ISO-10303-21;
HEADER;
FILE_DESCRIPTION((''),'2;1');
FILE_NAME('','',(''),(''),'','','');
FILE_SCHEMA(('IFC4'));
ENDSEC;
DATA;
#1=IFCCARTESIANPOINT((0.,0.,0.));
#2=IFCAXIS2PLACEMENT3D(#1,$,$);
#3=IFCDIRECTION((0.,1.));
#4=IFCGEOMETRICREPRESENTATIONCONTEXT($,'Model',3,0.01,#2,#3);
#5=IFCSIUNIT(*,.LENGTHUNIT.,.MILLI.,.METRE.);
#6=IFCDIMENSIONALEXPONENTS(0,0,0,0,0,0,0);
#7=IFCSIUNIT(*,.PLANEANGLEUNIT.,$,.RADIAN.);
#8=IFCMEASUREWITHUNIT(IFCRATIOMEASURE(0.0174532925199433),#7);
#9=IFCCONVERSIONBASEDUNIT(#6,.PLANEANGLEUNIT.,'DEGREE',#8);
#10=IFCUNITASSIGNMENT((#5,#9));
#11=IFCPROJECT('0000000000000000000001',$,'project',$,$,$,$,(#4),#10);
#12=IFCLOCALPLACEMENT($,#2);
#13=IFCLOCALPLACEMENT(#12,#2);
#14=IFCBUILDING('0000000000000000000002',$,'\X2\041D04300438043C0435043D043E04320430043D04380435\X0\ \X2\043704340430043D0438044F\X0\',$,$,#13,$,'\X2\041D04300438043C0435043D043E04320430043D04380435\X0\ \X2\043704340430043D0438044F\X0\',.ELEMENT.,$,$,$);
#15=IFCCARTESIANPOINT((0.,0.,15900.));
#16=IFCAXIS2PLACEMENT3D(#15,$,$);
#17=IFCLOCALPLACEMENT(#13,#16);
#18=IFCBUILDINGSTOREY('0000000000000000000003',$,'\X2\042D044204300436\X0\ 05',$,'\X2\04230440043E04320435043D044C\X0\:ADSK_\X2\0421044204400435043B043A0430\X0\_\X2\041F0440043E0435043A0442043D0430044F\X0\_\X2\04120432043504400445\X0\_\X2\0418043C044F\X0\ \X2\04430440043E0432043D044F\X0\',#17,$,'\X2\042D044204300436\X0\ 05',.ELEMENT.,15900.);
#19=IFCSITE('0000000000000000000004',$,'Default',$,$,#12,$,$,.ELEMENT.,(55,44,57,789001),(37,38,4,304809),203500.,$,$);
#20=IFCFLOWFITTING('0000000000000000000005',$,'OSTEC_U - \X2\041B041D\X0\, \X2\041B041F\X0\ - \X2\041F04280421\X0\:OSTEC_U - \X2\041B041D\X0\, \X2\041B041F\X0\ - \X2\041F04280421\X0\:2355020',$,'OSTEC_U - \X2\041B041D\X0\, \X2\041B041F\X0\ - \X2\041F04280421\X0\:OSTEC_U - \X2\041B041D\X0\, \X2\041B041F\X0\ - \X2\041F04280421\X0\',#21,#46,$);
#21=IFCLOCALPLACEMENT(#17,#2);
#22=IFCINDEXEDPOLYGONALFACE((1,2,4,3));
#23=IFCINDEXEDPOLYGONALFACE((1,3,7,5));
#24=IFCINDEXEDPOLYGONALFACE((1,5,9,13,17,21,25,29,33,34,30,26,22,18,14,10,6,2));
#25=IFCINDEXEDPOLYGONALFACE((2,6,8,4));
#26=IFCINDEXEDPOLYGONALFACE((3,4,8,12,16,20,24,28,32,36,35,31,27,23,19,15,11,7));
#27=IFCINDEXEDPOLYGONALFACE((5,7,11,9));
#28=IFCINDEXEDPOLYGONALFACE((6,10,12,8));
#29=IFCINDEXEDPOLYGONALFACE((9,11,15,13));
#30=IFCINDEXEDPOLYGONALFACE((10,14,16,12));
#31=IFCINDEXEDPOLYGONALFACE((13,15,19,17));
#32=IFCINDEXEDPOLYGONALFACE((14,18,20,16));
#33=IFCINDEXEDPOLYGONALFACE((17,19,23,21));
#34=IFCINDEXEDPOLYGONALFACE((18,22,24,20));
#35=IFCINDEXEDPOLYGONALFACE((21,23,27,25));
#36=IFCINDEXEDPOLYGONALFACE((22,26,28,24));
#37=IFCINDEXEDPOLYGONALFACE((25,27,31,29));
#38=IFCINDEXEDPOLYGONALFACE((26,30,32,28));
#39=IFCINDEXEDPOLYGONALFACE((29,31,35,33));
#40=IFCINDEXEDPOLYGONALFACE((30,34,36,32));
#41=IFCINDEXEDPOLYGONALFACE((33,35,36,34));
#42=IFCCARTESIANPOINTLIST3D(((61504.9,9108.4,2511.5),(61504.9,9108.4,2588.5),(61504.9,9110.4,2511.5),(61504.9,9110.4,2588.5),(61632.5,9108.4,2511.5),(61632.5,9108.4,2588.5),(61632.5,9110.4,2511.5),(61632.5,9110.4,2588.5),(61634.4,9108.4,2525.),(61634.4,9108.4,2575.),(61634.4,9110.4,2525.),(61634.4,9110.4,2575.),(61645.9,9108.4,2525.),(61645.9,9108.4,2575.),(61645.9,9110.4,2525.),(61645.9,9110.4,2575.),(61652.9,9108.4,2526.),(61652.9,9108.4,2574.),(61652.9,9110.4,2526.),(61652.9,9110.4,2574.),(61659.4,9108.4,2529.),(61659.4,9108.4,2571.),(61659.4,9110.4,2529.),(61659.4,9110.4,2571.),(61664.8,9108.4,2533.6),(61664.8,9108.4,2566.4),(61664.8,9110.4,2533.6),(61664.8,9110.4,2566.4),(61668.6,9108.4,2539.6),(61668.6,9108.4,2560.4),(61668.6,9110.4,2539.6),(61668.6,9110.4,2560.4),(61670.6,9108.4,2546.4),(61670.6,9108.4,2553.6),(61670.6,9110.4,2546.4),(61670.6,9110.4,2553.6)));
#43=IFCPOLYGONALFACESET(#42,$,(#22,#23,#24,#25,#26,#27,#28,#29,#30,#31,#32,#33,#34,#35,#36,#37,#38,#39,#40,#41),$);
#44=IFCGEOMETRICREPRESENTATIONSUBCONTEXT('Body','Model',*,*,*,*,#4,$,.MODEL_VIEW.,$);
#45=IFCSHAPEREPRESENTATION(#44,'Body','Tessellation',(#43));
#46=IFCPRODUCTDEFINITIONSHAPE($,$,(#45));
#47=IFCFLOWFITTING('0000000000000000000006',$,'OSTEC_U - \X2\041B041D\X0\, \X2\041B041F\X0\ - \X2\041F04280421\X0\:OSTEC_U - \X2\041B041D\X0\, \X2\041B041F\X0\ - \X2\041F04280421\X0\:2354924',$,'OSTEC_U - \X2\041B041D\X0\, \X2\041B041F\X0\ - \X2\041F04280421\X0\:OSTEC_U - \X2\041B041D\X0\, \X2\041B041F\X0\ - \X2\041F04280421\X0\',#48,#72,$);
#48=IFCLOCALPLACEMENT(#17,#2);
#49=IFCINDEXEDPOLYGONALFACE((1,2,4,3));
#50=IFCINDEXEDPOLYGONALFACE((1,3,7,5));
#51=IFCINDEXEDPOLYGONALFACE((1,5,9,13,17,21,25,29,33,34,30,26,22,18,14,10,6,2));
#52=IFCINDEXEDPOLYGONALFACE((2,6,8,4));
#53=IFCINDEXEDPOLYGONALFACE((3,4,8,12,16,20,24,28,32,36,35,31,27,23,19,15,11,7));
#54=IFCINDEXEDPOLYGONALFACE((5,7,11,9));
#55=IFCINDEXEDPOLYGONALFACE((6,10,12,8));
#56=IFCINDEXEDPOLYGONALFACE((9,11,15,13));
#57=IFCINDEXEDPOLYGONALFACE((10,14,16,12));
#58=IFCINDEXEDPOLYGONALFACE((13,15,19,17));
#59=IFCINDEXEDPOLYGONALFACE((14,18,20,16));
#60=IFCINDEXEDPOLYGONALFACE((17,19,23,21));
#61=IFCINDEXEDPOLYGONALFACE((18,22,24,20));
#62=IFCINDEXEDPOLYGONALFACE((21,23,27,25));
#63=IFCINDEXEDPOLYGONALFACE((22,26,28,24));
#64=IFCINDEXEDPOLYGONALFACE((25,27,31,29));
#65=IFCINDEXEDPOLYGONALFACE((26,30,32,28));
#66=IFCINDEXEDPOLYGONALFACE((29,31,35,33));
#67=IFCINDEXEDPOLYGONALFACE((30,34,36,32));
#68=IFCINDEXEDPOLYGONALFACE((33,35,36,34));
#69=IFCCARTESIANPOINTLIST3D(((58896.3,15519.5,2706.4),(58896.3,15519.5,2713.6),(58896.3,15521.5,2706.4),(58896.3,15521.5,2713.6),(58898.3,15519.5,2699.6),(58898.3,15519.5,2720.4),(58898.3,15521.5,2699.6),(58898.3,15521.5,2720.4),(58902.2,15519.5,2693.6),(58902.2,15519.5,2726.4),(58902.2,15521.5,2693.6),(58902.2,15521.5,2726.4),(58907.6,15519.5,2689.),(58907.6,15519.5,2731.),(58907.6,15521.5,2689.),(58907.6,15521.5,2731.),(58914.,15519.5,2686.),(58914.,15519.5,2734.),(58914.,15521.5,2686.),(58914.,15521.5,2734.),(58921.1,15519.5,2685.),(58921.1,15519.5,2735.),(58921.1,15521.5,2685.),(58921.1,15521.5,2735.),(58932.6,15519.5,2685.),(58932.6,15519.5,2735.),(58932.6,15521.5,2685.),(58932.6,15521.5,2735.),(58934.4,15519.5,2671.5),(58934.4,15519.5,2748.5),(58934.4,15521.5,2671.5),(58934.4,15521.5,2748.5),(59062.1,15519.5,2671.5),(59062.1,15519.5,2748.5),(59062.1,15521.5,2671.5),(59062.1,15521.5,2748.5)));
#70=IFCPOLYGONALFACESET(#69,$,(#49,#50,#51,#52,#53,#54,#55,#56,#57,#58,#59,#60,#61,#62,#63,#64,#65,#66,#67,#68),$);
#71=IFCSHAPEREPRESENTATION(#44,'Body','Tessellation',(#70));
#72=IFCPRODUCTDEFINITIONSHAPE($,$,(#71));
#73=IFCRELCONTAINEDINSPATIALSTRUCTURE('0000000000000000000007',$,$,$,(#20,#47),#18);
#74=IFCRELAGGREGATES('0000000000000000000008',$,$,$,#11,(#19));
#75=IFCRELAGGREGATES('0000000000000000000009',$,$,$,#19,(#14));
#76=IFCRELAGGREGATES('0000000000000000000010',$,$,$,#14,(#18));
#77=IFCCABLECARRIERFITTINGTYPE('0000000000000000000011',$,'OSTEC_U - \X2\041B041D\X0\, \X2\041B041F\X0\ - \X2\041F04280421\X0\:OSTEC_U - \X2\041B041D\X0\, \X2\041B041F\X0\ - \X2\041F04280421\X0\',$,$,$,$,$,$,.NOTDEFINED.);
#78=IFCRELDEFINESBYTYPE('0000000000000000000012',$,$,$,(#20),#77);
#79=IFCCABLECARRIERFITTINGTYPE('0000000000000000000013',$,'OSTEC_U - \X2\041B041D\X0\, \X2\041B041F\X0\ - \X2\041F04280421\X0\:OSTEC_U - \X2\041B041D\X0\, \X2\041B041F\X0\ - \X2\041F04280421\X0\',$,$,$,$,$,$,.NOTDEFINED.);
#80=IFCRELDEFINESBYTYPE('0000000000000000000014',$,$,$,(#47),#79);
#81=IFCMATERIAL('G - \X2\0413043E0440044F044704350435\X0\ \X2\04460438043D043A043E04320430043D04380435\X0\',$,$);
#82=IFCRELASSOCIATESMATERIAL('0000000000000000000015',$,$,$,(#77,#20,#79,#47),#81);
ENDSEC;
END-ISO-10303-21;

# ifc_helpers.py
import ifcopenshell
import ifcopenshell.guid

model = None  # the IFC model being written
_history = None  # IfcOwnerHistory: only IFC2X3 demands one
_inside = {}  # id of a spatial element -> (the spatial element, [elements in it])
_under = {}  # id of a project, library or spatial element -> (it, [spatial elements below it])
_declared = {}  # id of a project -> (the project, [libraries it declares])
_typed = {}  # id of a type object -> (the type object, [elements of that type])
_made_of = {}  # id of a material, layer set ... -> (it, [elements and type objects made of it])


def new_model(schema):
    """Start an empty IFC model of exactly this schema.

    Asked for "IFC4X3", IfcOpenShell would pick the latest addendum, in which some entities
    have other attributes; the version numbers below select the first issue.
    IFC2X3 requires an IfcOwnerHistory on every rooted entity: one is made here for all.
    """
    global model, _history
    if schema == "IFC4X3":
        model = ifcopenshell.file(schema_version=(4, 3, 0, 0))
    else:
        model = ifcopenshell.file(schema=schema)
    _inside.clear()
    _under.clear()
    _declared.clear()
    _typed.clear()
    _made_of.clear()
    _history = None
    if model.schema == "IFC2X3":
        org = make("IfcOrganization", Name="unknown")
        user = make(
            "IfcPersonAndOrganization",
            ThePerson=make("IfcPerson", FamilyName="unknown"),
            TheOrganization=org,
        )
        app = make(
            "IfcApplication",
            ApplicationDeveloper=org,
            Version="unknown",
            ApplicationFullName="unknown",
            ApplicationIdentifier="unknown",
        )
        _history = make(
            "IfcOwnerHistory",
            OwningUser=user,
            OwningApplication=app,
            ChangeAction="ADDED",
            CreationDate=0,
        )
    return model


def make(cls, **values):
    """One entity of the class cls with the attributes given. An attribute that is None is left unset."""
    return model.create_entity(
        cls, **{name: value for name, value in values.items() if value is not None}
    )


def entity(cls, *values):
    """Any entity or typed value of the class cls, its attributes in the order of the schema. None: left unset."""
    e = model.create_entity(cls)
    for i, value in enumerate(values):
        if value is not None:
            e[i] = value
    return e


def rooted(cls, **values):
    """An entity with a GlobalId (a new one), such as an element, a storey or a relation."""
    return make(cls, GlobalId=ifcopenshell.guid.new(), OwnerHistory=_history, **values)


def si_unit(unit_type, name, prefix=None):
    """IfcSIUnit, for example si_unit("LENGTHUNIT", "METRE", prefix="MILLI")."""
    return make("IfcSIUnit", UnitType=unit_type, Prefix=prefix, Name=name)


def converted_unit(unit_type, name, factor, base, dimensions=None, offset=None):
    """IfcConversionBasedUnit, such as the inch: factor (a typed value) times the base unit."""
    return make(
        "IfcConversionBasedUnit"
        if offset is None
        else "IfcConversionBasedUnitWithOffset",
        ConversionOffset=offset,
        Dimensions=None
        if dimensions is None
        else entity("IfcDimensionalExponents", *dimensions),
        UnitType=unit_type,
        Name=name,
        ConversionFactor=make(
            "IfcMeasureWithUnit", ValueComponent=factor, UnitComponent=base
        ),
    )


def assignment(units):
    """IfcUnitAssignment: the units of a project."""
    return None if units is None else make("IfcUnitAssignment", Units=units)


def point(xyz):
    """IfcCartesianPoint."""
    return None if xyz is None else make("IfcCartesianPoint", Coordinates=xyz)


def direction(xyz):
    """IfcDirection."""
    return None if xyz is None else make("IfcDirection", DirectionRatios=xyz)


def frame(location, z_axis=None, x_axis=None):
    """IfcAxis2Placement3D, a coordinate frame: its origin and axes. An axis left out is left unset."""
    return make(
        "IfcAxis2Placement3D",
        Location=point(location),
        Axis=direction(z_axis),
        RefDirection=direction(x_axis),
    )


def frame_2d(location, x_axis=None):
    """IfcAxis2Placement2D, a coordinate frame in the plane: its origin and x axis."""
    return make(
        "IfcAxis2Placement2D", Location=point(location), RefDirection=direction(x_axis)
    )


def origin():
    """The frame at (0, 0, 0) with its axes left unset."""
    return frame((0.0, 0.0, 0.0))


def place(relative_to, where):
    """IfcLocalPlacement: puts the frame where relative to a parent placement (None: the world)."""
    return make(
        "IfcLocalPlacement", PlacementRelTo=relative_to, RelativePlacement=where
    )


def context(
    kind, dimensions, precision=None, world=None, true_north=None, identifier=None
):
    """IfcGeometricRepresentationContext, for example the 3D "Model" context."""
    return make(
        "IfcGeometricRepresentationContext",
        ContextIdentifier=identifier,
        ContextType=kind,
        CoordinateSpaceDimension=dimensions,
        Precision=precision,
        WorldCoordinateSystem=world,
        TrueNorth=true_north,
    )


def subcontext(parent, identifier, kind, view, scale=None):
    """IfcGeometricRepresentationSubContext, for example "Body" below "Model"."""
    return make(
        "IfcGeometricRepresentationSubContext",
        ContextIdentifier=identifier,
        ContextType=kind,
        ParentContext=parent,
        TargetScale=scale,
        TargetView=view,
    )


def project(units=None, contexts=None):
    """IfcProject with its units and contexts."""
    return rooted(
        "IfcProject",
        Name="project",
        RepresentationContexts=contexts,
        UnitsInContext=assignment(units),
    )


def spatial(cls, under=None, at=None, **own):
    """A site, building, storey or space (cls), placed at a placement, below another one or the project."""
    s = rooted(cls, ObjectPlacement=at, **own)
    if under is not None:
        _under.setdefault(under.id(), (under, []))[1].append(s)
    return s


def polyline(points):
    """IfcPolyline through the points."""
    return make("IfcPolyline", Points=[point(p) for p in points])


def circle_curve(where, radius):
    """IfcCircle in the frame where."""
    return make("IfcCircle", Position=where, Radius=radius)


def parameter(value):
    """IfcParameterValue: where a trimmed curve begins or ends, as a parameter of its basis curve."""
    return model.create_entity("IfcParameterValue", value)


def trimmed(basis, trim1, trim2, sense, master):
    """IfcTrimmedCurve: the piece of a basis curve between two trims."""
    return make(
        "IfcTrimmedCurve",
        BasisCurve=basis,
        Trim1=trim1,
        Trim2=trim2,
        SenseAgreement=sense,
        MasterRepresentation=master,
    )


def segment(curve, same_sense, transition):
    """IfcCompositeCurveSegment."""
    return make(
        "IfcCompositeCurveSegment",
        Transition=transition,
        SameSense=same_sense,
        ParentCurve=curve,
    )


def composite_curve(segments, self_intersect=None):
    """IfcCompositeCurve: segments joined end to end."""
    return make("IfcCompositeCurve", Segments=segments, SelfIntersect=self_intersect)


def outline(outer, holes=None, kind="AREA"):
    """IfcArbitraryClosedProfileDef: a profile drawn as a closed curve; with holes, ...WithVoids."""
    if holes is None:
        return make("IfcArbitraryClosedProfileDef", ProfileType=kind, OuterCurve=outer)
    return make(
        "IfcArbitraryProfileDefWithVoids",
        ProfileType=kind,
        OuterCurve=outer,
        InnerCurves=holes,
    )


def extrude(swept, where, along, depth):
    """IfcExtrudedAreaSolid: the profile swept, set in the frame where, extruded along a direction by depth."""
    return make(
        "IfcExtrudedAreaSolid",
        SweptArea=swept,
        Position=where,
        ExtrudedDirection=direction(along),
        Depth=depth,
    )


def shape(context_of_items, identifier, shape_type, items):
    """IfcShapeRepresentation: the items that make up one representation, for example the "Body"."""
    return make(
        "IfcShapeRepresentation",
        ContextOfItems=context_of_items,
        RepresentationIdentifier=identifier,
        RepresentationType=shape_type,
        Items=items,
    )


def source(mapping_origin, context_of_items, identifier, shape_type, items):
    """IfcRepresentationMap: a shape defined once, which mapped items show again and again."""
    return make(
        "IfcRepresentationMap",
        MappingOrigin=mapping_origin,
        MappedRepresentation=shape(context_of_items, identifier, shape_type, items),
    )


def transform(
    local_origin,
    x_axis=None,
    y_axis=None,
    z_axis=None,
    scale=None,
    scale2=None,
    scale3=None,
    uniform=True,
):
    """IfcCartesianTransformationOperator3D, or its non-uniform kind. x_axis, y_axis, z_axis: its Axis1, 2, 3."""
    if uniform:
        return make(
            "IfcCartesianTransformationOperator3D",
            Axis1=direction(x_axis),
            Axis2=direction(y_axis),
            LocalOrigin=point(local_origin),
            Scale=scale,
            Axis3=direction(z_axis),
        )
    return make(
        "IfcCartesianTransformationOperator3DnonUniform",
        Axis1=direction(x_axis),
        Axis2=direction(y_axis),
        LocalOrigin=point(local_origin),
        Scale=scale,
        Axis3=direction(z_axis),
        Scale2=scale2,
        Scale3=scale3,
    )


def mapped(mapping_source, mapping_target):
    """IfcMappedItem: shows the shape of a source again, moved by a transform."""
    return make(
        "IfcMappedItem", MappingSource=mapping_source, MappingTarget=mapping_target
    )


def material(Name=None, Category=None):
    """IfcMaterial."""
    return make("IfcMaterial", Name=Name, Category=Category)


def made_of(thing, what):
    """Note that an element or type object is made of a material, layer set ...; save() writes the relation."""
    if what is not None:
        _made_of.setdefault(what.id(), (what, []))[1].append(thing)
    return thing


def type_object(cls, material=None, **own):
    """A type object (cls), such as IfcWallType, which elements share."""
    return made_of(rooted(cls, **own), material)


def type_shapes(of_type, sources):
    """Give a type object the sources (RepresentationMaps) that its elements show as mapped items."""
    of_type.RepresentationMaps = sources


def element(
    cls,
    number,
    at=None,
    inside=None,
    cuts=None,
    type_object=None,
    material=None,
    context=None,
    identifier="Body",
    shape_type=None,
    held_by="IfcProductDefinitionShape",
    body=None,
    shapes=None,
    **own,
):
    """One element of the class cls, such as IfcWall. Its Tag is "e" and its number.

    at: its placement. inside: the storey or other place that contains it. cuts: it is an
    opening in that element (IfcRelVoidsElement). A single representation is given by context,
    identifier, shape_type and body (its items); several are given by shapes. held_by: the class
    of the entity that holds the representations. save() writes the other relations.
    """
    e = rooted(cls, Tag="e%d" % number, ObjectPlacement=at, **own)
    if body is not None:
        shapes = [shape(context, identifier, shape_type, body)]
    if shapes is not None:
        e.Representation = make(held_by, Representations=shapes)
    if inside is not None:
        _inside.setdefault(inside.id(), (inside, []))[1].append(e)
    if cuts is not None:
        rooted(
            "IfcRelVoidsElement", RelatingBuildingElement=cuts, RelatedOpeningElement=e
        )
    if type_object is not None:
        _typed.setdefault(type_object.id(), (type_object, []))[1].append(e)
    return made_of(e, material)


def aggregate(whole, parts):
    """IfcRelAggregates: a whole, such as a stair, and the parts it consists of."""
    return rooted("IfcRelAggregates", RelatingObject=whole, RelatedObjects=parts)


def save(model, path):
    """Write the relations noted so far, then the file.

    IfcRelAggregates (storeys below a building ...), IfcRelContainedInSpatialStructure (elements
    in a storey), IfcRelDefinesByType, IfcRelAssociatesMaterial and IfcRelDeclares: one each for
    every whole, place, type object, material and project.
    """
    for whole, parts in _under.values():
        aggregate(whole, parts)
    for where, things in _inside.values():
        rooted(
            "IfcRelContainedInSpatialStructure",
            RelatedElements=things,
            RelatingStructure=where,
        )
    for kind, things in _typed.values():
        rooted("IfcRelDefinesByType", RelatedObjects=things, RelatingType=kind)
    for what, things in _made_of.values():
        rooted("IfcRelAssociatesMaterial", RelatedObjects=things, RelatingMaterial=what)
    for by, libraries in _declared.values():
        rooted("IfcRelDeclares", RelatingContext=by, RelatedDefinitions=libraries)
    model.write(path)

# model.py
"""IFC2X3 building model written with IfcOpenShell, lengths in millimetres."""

from ifc_helpers import new_model, entity, si_unit, converted_unit, direction, frame, frame_2d, origin, place, context, subcontext, project, spatial, polyline, circle_curve, parameter, trimmed, segment, composite_curve, outline, extrude, source, transform, mapped, material, type_object, type_shapes, element, save


model = new_model("IFC2X3")

# Units and contexts
model_context = context("Model", 3, precision=0.01, world=origin(), true_north=direction((0.0, 1.0)))
body_context = subcontext(model_context, "Body", "Model", "MODEL_VIEW")
ifc_project = project(units=[si_unit("LENGTHUNIT", "METRE", prefix="MILLI"), converted_unit("PLANEANGLEUNIT", "DEGREE", entity("IfcRatioMeasure", 0.0174532925199433), si_unit("PLANEANGLEUNIT", "RADIAN"), dimensions=[0, 0, 0, 0, 0, 0, 0])], contexts=[model_context])

# Site, building, storey
site_placement = place(None, frame((0.0, 0.0, 0.0)))
site = spatial("IfcSite", under=ifc_project, at=site_placement, Name="Default", CompositionType="ELEMENT", RefLatitude=(55, 44, 57, 789001), RefLongitude=(37, 38, 4, 304809), RefElevation=203500.0)
building_placement = place(site_placement, origin())
building = spatial("IfcBuilding", under=site, at=building_placement, Name="Наименование здания", LongName="Наименование здания", CompositionType="ELEMENT")
storey_placement = place(building_placement, frame((0.0, 0.0, 15900.0)))
storey = spatial("IfcBuildingStorey", under=building, at=storey_placement, Name="Этаж 05", ObjectType="Уровень:ADSK_Стрелка_Проектная_Вверх_Имя уровня", LongName="Этаж 05", CompositionType="ELEMENT", Elevation=15900.0)

# Flow fittings
ifc_material_1 = material(Name="G - Горячее цинкование")
cable_carrier_fitting_type_1 = type_object("IfcCableCarrierFittingType", Name="OSTEC_U - ЛН, ЛП - ПШС:OSTEC_U - ЛН, ЛП - ПШС", PredefinedType="NOTDEFINED", material=ifc_material_1)
shared_shape_1 = source(origin(), body_context, "Body", "SweptSolid", [
    extrude(outline(composite_curve([segment(trimmed(circle_curve(frame_2d((-41.5, 0.0), x_axis=(1.0, 0.0)), 25.0), [parameter(90.0)], [parameter(270.0)], True, "PARAMETER"), True, "CONTINUOUS"), segment(polyline([(-41.5, -25.0), (-30.0, -25.0)]), True, "CONTINUOUS"), segment(polyline([(-30.0, -25.0), (-28.1, -38.5)]), True, "CONTINUOUS"), segment(polyline([(-28.1, -38.5), (99.5, -38.5)]), True, "CONTINUOUS"), segment(polyline([(99.5, -38.5), (99.5, 38.5)]), True, "CONTINUOUS"), segment(polyline([(99.5, 38.5), (-28.1, 38.5)]), True, "CONTINUOUS"), segment(polyline([(-28.1, 38.5), (-30.0, 25.0)]), True, "CONTINUOUS"), segment(polyline([(-30.0, 25.0), (-41.5, 25.0)]), True, "CONTINUOUS")], self_intersect=False)), frame((41.5, 0.0, 0.0), z_axis=(0.0, 0.0, -1.0), x_axis=(1.0, 0.0, 0.0)), (0.0, 0.0, -1.0), 2.0),
])
type_shapes(cable_carrier_fitting_type_1, [shared_shape_1])
flow_fitting_1_placement = place(storey_placement, frame((61645.9, 9108.4, 2550.0), z_axis=(0.0, 1.0, 0.0), x_axis=(-1.0, 0.0, 0.0)))
element("IfcFlowFitting", 1, at=flow_fitting_1_placement, inside=storey, type_object=cable_carrier_fitting_type_1, material=ifc_material_1, Name="OSTEC_U - ЛН, ЛП - ПШС:OSTEC_U - ЛН, ЛП - ПШС:2355020", ObjectType="OSTEC_U - ЛН, ЛП - ПШС:OSTEC_U - ЛН, ЛП - ПШС", context=body_context, shape_type="MappedRepresentation", body=[
    mapped(shared_shape_1, transform((0.0, 0.0, 0.0), scale=1.0)),
])
cable_carrier_fitting_type_2 = type_object("IfcCableCarrierFittingType", Name="OSTEC_U - ЛН, ЛП - ПШС:OSTEC_U - ЛН, ЛП - ПШС", PredefinedType="NOTDEFINED", material=ifc_material_1)
shared_shape_2 = source(origin(), body_context, "Body", "SweptSolid", [
    extrude(outline(composite_curve([segment(trimmed(circle_curve(frame_2d((-41.5, 0.0), x_axis=(1.0, 0.0)), 25.0), [parameter(90.0)], [parameter(270.0)], True, "PARAMETER"), True, "CONTINUOUS"), segment(polyline([(-41.5, -25.0), (-30.0, -25.0)]), True, "CONTINUOUS"), segment(polyline([(-30.0, -25.0), (-28.1, -38.5)]), True, "CONTINUOUS"), segment(polyline([(-28.1, -38.5), (99.5, -38.5)]), True, "CONTINUOUS"), segment(polyline([(99.5, -38.5), (99.5, 38.5)]), True, "CONTINUOUS"), segment(polyline([(99.5, 38.5), (-28.1, 38.5)]), True, "CONTINUOUS"), segment(polyline([(-28.1, 38.5), (-30.0, 25.0)]), True, "CONTINUOUS"), segment(polyline([(-30.0, 25.0), (-41.5, 25.0)]), True, "CONTINUOUS")], self_intersect=False)), frame((41.5, 0.0, 0.0)), (0.0, 0.0, 1.0), 2.0),
])
type_shapes(cable_carrier_fitting_type_2, [shared_shape_2])
flow_fitting_2_placement = place(storey_placement, frame((58921.1, 15521.5, 2710.0), z_axis=(0.0, -1.0, 0.0), x_axis=(1.0, 0.0, 0.0)))
element("IfcFlowFitting", 2, at=flow_fitting_2_placement, inside=storey, type_object=cable_carrier_fitting_type_2, material=ifc_material_1, Name="OSTEC_U - ЛН, ЛП - ПШС:OSTEC_U - ЛН, ЛП - ПШС:2354924", ObjectType="OSTEC_U - ЛН, ЛП - ПШС:OSTEC_U - ЛН, ЛП - ПШС", context=body_context, shape_type="MappedRepresentation", body=[
    mapped(shared_shape_2, transform((0.0, 0.0, 0.0), scale=1.0)),
])

save(model, "model.ifc")
